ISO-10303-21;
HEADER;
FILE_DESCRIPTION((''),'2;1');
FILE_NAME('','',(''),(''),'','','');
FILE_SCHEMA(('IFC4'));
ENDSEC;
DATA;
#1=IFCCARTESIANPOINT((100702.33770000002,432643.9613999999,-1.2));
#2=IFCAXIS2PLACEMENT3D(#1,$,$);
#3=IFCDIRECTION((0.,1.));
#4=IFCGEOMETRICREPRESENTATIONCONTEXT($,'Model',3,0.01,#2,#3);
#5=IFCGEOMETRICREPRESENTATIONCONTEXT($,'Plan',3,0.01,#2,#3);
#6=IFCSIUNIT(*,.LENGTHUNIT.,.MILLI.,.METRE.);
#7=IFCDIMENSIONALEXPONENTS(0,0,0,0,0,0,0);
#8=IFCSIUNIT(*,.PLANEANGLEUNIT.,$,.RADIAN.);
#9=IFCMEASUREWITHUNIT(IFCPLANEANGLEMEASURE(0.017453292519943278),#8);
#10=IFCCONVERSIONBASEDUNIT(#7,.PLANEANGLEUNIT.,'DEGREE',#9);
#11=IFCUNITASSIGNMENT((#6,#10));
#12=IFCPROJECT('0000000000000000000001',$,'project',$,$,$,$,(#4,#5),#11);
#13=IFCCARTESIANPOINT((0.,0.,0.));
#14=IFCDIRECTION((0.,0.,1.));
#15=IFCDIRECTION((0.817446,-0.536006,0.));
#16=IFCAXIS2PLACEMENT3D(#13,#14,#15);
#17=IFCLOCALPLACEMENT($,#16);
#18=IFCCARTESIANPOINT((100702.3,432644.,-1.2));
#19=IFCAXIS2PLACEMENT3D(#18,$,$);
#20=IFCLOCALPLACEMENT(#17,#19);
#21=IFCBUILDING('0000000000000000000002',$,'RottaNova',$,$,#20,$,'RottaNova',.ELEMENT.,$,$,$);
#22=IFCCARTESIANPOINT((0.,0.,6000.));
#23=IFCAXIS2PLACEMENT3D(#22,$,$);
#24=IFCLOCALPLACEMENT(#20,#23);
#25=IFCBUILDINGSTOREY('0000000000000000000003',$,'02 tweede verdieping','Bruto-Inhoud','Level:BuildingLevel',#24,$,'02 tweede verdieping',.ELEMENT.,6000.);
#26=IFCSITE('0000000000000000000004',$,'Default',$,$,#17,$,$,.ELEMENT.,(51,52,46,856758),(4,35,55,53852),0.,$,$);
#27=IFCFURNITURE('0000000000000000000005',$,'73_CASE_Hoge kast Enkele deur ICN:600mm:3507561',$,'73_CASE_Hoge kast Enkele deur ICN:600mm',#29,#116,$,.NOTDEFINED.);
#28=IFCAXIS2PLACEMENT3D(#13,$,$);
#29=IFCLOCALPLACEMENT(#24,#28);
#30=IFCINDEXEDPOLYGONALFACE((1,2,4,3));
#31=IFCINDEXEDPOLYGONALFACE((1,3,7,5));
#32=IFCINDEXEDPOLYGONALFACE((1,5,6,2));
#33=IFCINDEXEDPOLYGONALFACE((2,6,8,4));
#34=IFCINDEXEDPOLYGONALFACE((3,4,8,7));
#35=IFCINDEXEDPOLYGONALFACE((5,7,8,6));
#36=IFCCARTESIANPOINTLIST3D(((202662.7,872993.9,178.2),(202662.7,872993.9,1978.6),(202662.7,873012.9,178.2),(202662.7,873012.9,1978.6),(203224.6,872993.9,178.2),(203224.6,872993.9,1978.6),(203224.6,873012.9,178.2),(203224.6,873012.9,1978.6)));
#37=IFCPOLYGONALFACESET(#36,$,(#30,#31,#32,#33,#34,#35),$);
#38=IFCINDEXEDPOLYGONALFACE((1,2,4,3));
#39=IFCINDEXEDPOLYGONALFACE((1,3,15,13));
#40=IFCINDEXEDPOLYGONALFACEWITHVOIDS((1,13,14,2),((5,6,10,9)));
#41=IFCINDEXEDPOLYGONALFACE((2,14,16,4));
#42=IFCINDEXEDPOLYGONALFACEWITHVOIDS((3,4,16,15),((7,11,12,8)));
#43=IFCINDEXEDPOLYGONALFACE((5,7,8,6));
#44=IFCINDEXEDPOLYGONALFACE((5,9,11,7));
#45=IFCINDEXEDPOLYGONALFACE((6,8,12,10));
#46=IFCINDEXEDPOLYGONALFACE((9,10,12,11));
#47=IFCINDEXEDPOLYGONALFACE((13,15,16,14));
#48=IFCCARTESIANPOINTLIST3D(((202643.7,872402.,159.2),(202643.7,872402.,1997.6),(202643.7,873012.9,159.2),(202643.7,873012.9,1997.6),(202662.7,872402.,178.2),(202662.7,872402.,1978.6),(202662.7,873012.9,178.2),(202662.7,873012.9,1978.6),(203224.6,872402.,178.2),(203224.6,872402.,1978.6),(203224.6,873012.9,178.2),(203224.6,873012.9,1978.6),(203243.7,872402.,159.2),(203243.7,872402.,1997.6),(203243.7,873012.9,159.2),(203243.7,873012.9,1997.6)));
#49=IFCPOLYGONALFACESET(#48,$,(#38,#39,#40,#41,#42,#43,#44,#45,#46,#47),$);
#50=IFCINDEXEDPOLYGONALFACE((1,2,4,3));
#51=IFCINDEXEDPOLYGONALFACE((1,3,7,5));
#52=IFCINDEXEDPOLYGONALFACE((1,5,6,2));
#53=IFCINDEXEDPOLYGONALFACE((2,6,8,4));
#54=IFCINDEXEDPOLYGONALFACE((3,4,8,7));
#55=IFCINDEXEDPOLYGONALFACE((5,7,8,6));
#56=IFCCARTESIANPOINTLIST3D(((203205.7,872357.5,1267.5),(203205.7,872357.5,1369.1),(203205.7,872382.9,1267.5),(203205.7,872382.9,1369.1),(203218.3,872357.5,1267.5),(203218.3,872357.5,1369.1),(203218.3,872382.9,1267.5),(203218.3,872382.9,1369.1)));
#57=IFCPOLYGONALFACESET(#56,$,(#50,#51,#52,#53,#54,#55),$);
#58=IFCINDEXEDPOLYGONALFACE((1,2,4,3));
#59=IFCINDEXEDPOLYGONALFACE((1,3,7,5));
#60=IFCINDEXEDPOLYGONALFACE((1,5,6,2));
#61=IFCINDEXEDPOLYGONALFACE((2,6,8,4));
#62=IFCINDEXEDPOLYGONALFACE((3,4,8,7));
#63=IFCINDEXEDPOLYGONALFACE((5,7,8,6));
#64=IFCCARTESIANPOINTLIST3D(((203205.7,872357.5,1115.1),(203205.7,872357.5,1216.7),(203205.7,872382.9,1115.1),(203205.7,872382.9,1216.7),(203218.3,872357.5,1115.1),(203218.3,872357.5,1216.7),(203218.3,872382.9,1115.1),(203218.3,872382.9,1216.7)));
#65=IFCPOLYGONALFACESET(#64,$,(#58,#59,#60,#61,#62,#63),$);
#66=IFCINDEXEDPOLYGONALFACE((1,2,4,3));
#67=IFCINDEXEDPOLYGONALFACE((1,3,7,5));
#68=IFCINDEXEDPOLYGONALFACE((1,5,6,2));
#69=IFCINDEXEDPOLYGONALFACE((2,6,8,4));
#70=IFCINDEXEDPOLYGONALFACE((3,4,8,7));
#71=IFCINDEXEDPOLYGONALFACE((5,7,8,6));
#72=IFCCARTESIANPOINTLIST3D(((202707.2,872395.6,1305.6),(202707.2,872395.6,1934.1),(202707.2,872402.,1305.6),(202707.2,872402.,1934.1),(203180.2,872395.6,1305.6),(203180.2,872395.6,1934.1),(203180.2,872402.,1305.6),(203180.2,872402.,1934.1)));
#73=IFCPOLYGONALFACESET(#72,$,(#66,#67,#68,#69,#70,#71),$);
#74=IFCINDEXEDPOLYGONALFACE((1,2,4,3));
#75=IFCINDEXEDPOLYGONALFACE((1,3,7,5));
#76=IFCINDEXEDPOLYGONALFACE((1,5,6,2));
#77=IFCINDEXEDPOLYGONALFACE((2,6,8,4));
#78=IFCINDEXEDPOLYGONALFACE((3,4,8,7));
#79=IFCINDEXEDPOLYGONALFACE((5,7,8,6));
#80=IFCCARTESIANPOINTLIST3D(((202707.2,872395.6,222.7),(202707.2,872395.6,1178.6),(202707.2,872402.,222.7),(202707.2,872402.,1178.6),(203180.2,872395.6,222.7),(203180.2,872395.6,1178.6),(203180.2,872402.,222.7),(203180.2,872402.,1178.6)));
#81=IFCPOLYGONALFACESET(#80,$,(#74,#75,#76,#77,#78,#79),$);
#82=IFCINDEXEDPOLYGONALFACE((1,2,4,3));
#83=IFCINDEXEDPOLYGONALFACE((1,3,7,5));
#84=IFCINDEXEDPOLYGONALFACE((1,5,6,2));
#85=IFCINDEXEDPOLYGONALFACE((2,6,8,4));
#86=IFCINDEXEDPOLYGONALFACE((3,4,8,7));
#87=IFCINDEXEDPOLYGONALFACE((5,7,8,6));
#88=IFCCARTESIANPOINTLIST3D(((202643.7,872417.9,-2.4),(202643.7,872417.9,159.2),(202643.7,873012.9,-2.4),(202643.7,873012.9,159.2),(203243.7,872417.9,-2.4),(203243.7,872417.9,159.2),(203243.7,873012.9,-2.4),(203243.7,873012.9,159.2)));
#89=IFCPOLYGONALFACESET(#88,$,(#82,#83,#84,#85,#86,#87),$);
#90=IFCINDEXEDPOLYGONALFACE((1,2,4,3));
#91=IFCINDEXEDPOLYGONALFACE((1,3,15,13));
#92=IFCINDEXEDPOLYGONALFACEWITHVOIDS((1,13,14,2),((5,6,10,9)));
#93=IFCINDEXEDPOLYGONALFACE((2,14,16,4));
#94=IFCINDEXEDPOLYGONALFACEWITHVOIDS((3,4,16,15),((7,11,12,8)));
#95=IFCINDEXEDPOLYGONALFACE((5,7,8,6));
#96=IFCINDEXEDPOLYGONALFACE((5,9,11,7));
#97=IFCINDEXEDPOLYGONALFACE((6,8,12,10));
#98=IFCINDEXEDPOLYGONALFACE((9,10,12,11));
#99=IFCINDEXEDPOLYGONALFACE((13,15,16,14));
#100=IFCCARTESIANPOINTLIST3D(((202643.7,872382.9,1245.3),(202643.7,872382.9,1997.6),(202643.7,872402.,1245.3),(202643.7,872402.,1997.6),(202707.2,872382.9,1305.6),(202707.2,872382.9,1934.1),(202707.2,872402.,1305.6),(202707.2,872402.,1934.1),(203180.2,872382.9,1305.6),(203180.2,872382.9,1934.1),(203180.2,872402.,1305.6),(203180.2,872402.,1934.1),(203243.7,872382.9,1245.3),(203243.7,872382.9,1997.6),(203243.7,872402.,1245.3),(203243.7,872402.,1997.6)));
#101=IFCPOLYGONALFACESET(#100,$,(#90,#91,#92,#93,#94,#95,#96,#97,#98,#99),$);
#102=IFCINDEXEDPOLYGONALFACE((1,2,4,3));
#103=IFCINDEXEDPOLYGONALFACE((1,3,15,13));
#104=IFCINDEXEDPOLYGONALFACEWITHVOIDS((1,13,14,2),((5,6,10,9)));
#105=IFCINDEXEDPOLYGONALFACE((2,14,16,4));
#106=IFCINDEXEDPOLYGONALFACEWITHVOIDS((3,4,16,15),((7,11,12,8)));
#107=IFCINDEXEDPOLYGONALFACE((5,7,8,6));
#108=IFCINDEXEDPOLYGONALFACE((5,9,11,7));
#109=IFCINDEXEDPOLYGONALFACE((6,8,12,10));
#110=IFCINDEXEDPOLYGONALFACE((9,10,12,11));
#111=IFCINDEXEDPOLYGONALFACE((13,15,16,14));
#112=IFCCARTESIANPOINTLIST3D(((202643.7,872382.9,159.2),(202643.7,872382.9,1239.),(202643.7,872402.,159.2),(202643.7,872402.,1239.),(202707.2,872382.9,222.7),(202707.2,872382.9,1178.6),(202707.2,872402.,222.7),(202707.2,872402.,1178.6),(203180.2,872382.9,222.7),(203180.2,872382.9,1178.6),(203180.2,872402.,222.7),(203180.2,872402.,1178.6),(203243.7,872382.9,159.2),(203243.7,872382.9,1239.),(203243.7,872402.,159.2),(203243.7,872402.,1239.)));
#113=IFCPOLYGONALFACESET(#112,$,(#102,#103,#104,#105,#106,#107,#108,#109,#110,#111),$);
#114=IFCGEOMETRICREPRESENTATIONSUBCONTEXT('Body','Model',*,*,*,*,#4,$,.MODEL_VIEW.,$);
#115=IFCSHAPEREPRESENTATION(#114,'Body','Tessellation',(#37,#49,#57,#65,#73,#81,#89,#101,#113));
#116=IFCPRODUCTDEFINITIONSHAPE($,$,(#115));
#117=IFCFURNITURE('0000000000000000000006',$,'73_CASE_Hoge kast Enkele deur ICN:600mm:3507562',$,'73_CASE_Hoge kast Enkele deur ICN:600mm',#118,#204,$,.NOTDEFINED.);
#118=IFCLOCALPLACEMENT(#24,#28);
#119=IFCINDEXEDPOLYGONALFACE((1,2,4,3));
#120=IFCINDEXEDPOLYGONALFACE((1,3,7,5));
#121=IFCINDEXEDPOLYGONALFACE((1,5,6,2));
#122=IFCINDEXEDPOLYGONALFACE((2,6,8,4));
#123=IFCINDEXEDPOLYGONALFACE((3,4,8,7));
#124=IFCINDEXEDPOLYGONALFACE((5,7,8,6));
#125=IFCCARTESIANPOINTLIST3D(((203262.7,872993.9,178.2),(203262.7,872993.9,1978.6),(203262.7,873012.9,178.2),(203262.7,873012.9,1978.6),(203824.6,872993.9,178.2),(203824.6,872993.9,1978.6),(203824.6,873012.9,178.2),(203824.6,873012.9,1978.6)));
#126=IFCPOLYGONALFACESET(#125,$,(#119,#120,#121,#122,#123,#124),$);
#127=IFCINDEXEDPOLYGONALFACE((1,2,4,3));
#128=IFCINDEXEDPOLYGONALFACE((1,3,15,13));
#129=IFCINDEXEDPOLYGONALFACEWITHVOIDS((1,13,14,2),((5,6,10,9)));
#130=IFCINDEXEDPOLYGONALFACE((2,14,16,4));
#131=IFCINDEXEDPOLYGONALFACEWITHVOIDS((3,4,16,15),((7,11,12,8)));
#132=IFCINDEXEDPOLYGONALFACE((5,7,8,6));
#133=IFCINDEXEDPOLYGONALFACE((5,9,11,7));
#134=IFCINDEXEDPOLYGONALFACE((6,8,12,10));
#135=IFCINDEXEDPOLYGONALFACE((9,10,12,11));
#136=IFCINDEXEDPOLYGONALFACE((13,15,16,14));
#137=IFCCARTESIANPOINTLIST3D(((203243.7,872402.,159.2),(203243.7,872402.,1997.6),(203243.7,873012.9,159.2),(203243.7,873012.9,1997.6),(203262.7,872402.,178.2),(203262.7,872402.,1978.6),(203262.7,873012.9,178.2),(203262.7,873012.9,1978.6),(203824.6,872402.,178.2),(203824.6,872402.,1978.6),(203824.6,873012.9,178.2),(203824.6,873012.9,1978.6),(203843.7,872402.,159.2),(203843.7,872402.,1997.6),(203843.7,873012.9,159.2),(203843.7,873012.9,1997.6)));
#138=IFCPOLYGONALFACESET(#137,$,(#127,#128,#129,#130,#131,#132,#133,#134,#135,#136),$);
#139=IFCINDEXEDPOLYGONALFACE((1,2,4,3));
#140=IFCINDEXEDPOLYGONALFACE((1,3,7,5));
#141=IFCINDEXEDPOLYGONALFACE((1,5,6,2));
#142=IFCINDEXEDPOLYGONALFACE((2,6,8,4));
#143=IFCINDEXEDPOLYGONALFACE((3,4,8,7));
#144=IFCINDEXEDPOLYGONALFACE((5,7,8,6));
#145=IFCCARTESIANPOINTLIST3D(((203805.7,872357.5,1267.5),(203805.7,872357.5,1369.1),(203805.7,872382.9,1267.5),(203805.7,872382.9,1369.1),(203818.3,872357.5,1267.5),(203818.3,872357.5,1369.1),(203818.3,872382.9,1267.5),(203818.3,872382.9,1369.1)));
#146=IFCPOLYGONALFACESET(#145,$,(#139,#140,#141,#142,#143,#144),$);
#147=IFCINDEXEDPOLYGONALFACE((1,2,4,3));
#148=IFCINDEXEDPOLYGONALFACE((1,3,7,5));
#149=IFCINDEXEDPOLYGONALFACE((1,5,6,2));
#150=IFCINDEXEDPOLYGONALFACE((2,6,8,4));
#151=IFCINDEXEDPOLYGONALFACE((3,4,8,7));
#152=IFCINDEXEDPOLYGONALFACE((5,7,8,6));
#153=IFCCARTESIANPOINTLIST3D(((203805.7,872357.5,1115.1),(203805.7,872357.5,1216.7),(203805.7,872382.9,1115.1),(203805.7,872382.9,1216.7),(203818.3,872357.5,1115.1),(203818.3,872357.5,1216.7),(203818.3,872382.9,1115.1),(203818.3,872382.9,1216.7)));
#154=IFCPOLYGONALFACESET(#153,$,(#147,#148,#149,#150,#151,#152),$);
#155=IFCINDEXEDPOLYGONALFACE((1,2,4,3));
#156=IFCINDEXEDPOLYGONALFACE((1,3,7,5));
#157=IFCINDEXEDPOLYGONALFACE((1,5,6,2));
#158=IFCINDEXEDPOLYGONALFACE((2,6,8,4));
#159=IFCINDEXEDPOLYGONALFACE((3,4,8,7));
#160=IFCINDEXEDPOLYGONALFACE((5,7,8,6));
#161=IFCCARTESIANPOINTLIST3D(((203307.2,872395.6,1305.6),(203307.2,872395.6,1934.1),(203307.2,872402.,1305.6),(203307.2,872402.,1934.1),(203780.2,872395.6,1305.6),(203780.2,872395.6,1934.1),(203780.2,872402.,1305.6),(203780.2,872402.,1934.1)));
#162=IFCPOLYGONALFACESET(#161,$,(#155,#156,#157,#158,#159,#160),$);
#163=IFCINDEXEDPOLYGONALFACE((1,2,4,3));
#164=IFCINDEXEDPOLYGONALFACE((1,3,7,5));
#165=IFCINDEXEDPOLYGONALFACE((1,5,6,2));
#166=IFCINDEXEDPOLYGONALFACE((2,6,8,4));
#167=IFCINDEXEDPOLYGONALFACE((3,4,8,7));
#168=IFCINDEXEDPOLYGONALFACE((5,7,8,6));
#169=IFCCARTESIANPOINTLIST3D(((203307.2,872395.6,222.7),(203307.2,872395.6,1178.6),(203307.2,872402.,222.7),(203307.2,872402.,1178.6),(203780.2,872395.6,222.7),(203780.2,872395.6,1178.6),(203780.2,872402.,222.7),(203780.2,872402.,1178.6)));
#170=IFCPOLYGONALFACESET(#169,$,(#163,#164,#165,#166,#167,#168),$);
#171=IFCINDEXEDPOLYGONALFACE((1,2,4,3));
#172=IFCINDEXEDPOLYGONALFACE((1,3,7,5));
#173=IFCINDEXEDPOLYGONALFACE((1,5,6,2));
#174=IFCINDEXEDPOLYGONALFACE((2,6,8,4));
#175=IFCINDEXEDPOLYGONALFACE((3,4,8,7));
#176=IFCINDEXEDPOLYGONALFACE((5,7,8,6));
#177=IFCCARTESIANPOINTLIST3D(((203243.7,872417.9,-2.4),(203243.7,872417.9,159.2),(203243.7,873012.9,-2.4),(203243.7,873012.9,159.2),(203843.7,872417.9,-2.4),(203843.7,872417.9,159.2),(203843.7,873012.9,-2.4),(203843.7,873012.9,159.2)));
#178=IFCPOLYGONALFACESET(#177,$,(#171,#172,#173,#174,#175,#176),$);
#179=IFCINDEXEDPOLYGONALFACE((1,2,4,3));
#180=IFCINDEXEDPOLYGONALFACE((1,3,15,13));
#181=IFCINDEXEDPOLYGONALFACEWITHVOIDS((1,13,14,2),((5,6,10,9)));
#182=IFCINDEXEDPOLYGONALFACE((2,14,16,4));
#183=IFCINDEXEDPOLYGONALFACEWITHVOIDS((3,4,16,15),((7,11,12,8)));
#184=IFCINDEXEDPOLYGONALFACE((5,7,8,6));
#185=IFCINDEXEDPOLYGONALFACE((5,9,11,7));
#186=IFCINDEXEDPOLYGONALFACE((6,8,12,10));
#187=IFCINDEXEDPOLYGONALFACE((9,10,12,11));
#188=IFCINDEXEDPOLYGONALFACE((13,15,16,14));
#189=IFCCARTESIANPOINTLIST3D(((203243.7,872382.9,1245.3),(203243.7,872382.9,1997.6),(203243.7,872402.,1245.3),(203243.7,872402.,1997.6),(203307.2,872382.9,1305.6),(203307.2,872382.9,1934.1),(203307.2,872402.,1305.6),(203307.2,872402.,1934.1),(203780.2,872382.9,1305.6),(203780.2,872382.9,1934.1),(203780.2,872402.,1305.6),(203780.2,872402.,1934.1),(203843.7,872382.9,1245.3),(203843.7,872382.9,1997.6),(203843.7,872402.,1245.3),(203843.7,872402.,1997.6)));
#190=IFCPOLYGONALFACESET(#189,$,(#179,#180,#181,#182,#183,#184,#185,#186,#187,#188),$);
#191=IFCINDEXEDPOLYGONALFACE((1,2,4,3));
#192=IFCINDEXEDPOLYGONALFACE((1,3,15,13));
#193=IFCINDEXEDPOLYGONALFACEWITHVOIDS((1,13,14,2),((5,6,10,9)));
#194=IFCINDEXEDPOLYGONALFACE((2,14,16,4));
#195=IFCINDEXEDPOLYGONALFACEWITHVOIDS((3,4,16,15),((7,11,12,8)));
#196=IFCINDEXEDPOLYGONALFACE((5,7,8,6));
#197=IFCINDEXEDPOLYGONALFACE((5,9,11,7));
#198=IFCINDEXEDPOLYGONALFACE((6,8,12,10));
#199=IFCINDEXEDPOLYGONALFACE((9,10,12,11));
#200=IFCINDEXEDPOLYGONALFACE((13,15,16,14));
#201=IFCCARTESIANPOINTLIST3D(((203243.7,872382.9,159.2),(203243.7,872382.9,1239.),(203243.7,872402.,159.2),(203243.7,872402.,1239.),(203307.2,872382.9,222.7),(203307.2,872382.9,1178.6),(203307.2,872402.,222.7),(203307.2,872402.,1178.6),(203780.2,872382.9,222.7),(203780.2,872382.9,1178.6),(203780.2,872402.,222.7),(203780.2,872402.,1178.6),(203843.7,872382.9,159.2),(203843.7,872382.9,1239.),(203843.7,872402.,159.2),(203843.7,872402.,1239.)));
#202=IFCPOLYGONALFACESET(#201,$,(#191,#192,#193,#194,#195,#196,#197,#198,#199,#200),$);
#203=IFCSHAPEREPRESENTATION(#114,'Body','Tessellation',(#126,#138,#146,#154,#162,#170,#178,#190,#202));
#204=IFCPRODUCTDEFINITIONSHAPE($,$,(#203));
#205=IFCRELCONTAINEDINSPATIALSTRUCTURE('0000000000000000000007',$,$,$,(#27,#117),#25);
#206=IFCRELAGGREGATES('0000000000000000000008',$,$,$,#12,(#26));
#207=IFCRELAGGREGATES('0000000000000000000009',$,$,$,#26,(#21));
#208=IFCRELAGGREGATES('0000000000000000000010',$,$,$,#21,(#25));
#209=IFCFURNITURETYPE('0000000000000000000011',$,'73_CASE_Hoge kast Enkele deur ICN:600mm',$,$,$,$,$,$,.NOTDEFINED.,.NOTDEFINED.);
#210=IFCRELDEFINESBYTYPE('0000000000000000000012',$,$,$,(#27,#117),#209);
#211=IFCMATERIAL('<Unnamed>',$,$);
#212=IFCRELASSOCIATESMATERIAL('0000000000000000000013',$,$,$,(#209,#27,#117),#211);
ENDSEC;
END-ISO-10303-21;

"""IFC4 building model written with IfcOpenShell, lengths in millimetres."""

from ifc_helpers import new_model, entity, si_unit, converted_unit, direction, frame, place, context, subcontext, project, spatial, indexed_curve, outline, extrude, source, transform, mapped, material, type_object, type_shapes, element, save


model = new_model("IFC4")

# Units and contexts
model_context = context("Model", 3, precision=0.01, world=frame((100702.33770000002, 432643.9613999999, -1.2)), true_north=direction((0.0, 1.0)))
plan_context = context("Plan", 3, precision=0.01, world=frame((100702.33770000002, 432643.9613999999, -1.2)), true_north=direction((0.0, 1.0)))
body_context = subcontext(model_context, "Body", "Model", "MODEL_VIEW")
ifc_project = project(units=[si_unit("LENGTHUNIT", "METRE", prefix="MILLI"), converted_unit("PLANEANGLEUNIT", "DEGREE", entity("IfcPlaneAngleMeasure", 0.017453292519943278), si_unit("PLANEANGLEUNIT", "RADIAN"), dimensions=[0, 0, 0, 0, 0, 0, 0])], contexts=[model_context, plan_context])

# Site, building, storey
site_placement = place(None, frame((0.0, 0.0, 0.0), z_axis=(0.0, 0.0, 1.0), x_axis=(0.817446, -0.536006, 0.0)))
site = spatial("IfcSite", under=ifc_project, at=site_placement, Name="Default", CompositionType="ELEMENT", RefLatitude=(51, 52, 46, 856758), RefLongitude=(4, 35, 55, 53852), RefElevation=0.0)
building_placement = place(site_placement, frame((100702.3, 432644.0, -1.2)))
building = spatial("IfcBuilding", under=site, at=building_placement, Name="RottaNova", LongName="RottaNova", CompositionType="ELEMENT")
storey_placement = place(building_placement, frame((0.0, 0.0, 6000.0)))
storey = spatial("IfcBuildingStorey", under=building, at=storey_placement, Name="02 tweede verdieping", Description="Bruto-Inhoud", ObjectType="Level:BuildingLevel", LongName="02 tweede verdieping", CompositionType="ELEMENT", Elevation=6000.0)

# Furniture
ifc_material_1 = material(Name="<Unnamed>")
furniture_type = type_object("IfcFurnitureType", Name="73_CASE_Hoge kast Enkele deur ICN:600mm", AssemblyPlace="NOTDEFINED", PredefinedType="NOTDEFINED", material=ifc_material_1)
shared_shape_1 = source(frame((100702.3, 432644.0, -1.2)), body_context, "Body", "SweptSolid", [
    extrude(outline(indexed_curve([(-9.5, -280.9), (9.5, -280.9), (9.5, 280.9), (-9.5, 280.9), (-9.5, -280.9)], self_intersect=False)), frame((18.7, -9.5, 180.6), z_axis=(0.0, 0.0, 1.0), x_axis=(0.0, 1.0, 0.0)), (0.0, 0.0, 1.0), 1800.3),
    extrude(outline(indexed_curve([(-300.0, -919.2), (300.0, -919.2), (300.0, 919.2), (-300.0, 919.2), (-300.0, -919.2)], self_intersect=False), holes=[indexed_curve([(-280.9, 900.2), (281.0, 900.2), (281.0, -900.2), (-280.9, -900.2), (-280.9, 900.2)], self_intersect=False)]), frame((18.7, -610.9, 1080.8), z_axis=(0.0, 1.0, 0.0), x_axis=(-1.0, 0.0, 0.0)), (0.0, 0.0, 1.0), 610.9),
    extrude(outline(indexed_curve([(-12.7, -6.3), (12.7, -6.3), (12.7, 6.3), (-12.7, 6.3), (-12.7, -6.3)], self_intersect=False)), frame((287.1, -642.7, 1269.9), z_axis=(0.0, 0.0, 1.0), x_axis=(0.0, 1.0, 0.0)), (0.0, 0.0, 1.0), 101.6),
    extrude(outline(indexed_curve([(-12.7, -6.3), (12.7, -6.3), (12.7, 6.3), (-12.7, 6.3), (-12.7, -6.3)], self_intersect=False)), frame((287.1, -642.7, 1117.5), z_axis=(0.0, 0.0, 1.0), x_axis=(0.0, 1.0, 0.0)), (0.0, 0.0, 1.0), 101.6),
    extrude(outline(indexed_curve([(-3.2, -236.5), (3.2, -236.5), (3.2, 236.5), (-3.2, 236.5), (-3.2, -236.5)], self_intersect=False)), frame((18.7, -614.1, 1308.0), z_axis=(0.0, 0.0, 1.0), x_axis=(0.0, 1.0, 0.0)), (0.0, 0.0, 1.0), 628.5),
    extrude(outline(indexed_curve([(-3.2, -236.5), (3.2, -236.5), (3.2, 236.5), (-3.2, 236.5), (-3.2, -236.5)], self_intersect=False)), frame((18.7, -614.1, 225.1), z_axis=(0.0, 0.0, 1.0), x_axis=(0.0, 1.0, 0.0)), (0.0, 0.0, 1.0), 956.0),
    extrude(outline(indexed_curve([(-300.0, -297.5), (300.0, -297.5), (300.0, 297.5), (-300.0, 297.5), (-300.0, -297.5)], self_intersect=False)), frame((18.7, -297.5, 0.0), z_axis=(0.0, 0.0, 1.0), x_axis=(-1.0, 0.0, 0.0)), (0.0, 0.0, 1.0), 161.6),
    extrude(outline(indexed_curve([(-376.1, -300.0), (376.1, -300.0), (376.1, 300.0), (-376.1, 300.0), (-376.1, -300.0)], self_intersect=False), holes=[indexed_curve([(-312.6, -236.5), (-312.6, 236.5), (315.8, 236.5), (315.8, -236.5), (-312.6, -236.5)], self_intersect=False)]), frame((18.7, -630.0, 1623.9), z_axis=(0.0, 1.0, 0.0), x_axis=(0.0, 0.0, -1.0)), (0.0, 0.0, 1.0), 19.1),
    extrude(outline(indexed_curve([(-300.0, -539.9), (300.0, -539.9), (300.0, 539.9), (-300.0, 539.9), (-300.0, -539.9)], self_intersect=False), holes=[indexed_curve([(-236.5, 479.6), (236.5, 479.6), (236.5, -476.4), (-236.5, -476.4), (-236.5, 479.6)], self_intersect=False)]), frame((18.7, -630.0, 701.5), z_axis=(0.0, 1.0, 0.0), x_axis=(-1.0, 0.0, 0.0)), (0.0, 0.0, 1.0), 19.1),
])
type_shapes(furniture_type, [shared_shape_1])
for number, where, name in (
    (1, (1520.3, 7725.0, 0.0), "73_CASE_Hoge kast Enkele deur ICN:600mm:3507561"),
    (2, (2120.3, 7725.0, 0.0), "73_CASE_Hoge kast Enkele deur ICN:600mm:3507562"),
):
    element("IfcFurniture", number, at=place(storey_placement, frame(where)), inside=storey, type_object=furniture_type, material=ifc_material_1, Name=name, ObjectType="73_CASE_Hoge kast Enkele deur ICN:600mm", PredefinedType="NOTDEFINED", context=body_context, shape_type="MappedRepresentation", body=[
        mapped(shared_shape_1, transform((100702.3, 432644.0, -1.2), scale=1.0)),
    ])

save(model, "model.ifc")
